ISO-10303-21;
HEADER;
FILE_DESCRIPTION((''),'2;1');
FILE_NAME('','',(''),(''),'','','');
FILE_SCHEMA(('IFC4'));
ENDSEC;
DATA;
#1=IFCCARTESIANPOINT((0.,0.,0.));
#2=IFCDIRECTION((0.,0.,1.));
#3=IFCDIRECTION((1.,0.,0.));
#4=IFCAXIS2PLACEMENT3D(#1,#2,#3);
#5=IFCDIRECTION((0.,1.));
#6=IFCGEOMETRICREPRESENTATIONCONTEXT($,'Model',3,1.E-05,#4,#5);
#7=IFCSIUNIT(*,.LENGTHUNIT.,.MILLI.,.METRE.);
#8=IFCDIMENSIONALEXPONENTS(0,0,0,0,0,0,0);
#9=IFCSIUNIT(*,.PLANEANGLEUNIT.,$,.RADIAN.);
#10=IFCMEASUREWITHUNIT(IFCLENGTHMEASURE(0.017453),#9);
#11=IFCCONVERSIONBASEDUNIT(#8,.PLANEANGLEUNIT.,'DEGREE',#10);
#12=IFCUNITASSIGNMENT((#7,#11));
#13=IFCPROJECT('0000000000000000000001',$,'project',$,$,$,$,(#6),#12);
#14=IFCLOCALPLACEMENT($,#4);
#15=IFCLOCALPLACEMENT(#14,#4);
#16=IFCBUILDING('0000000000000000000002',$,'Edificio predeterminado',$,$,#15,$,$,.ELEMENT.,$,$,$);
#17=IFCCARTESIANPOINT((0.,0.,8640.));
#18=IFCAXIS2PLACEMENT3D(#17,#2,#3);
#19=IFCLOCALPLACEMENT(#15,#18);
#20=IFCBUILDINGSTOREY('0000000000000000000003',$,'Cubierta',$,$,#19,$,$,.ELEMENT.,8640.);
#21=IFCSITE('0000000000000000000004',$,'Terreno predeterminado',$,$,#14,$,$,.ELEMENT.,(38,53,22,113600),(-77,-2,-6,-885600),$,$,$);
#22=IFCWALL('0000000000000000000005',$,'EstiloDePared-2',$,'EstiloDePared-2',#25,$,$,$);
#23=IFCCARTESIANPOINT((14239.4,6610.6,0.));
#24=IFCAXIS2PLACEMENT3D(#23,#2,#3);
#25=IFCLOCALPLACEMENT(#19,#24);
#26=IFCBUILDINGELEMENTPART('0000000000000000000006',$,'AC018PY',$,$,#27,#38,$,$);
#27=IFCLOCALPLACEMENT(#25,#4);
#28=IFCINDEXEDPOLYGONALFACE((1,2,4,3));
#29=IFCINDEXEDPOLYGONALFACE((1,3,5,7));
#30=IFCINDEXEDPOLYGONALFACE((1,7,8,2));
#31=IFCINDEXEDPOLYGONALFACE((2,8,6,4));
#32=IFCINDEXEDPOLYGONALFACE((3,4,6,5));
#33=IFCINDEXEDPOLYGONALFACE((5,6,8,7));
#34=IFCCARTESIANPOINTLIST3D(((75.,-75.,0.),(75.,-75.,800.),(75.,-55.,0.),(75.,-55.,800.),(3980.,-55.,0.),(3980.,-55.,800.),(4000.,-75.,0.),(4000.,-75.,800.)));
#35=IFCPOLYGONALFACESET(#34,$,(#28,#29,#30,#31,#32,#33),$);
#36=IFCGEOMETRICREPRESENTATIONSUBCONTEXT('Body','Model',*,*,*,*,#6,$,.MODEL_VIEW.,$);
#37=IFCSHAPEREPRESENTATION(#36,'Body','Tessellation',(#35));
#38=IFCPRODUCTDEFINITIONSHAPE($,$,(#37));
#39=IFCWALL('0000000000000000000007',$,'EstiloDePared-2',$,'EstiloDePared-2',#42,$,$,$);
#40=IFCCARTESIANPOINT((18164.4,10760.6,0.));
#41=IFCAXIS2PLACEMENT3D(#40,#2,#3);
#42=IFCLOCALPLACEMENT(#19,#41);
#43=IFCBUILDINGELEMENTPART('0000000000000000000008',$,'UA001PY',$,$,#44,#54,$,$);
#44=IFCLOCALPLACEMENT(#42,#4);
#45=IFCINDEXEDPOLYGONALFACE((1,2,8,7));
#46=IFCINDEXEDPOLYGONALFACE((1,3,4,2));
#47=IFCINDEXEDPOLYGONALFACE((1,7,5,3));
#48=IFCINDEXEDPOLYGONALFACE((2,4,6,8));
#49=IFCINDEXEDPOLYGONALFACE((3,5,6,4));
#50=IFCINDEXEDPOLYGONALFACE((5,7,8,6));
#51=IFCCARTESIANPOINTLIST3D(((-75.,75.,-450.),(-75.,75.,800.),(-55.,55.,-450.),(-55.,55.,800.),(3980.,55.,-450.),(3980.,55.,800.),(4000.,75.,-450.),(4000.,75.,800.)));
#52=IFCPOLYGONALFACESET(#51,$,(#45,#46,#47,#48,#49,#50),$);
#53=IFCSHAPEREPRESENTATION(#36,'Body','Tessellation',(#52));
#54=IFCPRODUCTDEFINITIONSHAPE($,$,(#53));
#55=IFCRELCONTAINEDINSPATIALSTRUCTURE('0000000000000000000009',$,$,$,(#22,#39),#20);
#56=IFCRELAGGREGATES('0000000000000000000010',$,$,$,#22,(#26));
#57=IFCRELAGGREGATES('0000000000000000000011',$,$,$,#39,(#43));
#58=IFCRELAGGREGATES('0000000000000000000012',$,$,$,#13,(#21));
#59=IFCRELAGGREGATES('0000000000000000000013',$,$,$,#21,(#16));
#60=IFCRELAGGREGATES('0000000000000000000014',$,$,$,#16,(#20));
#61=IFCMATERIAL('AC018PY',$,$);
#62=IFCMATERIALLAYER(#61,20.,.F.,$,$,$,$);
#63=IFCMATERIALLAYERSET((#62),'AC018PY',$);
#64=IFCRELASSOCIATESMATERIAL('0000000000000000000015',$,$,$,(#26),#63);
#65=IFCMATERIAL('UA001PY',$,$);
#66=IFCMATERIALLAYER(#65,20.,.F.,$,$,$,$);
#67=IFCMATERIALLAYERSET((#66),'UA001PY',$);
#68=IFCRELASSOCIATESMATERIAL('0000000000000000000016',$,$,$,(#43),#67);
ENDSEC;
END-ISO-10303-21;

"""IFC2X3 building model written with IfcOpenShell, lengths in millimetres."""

from ifc_helpers import new_model, entity, si_unit, converted_unit, direction, frame, origin_with_axes, place, context, subcontext, project, spatial, polyline, outline, extrude, material, layer, layer_set, layer_usage, element, aggregate, save


model = new_model("IFC2X3")

# Units and contexts
model_context = context("Model", 3, precision=1e-05, world=origin_with_axes(), true_north=direction((0.0, 1.0)))
body_context = subcontext(model_context, "Body", "Model", "MODEL_VIEW")
ifc_project = project(units=[si_unit("LENGTHUNIT", "METRE", prefix="MILLI"), converted_unit("PLANEANGLEUNIT", "DEGREE", entity("IfcLengthMeasure", 0.017453), si_unit("PLANEANGLEUNIT", "RADIAN"), dimensions=[0, 0, 0, 0, 0, 0, 0])], contexts=[model_context])

# Site, building, storey
site_placement = place(None, origin_with_axes())
site = spatial("IfcSite", under=ifc_project, at=site_placement, Name="Terreno predeterminado", CompositionType="ELEMENT", RefLatitude=(38, 53, 22, 113600), RefLongitude=(-77, -2, -6, -885600))
building_placement = place(site_placement, origin_with_axes())
building = spatial("IfcBuilding", under=site, at=building_placement, Name="Edificio predeterminado", CompositionType="ELEMENT")
storey_placement = place(building_placement, frame((0.0, 0.0, 8640.0), z_axis=(0.0, 0.0, 1.0), x_axis=(1.0, 0.0, 0.0)))
storey = spatial("IfcBuildingStorey", under=building, at=storey_placement, Name="Cubierta", CompositionType="ELEMENT", Elevation=8640.0)

# Walls, building element parts
wall_1_placement = place(storey_placement, frame((14239.4, 6610.6, 0.0), z_axis=(0.0, 0.0, 1.0), x_axis=(1.0, 0.0, 0.0)))
wall_1 = element("IfcWall", 1, at=wall_1_placement, inside=storey, Name="EstiloDePared-2", ObjectType="EstiloDePared-2")
ifc_material_1 = material(Name="AC018PY")
ifc_layer_1 = layer(ifc_material_1, 20.0, ventilated=False)
ifc_layer_set_1 = layer_set([ifc_layer_1], Name="AC018PY")
ifc_layer_usage_1 = layer_usage(ifc_layer_set_1, "AXIS2", "NEGATIVE", 55.0)
building_element_part_1_placement = place(wall_1_placement, origin_with_axes())
building_element_part_1 = element("IfcBuildingElementPart", 2, at=building_element_part_1_placement, material=ifc_layer_usage_1, Name="AC018PY", context=body_context, shape_type="SweptSolid", body=[
    extrude(outline(polyline([(3980.0, -55.0), (4000.0, -75.0), (75.0, -75.0), (75.0, -55.0), (3980.0, -55.0)])), origin_with_axes(), (0.0, 0.0, 1.0), 800.0),
])
aggregate(wall_1, [building_element_part_1])
wall_2_placement = place(storey_placement, frame((18164.4, 10760.6, 0.0), z_axis=(0.0, 0.0, 1.0), x_axis=(1.0, 0.0, 0.0)))
wall_2 = element("IfcWall", 3, at=wall_2_placement, inside=storey, Name="EstiloDePared-2", ObjectType="EstiloDePared-2")
ifc_material_2 = material(Name="UA001PY")
ifc_layer_2 = layer(ifc_material_2, 20.0, ventilated=False)
ifc_layer_set_2 = layer_set([ifc_layer_2], Name="UA001PY")
ifc_layer_usage_2 = layer_usage(ifc_layer_set_2, "AXIS2", "NEGATIVE", -75.0)
building_element_part_2_placement = place(wall_2_placement, origin_with_axes())
building_element_part_2 = element("IfcBuildingElementPart", 4, at=building_element_part_2_placement, material=ifc_layer_usage_2, Name="UA001PY", context=body_context, shape_type="SweptSolid", body=[
    extrude(outline(polyline([(4000.0, 75.0), (3980.0, 55.0), (-55.0, 55.0), (-75.0, 75.0), (4000.0, 75.0)])), frame((0.0, 0.0, -450.0), z_axis=(0.0, 0.0, 1.0), x_axis=(1.0, 0.0, 0.0)), (0.0, 0.0, 1.0), 1250.0),
])
aggregate(wall_2, [building_element_part_2])

save(model, "model.ifc")
